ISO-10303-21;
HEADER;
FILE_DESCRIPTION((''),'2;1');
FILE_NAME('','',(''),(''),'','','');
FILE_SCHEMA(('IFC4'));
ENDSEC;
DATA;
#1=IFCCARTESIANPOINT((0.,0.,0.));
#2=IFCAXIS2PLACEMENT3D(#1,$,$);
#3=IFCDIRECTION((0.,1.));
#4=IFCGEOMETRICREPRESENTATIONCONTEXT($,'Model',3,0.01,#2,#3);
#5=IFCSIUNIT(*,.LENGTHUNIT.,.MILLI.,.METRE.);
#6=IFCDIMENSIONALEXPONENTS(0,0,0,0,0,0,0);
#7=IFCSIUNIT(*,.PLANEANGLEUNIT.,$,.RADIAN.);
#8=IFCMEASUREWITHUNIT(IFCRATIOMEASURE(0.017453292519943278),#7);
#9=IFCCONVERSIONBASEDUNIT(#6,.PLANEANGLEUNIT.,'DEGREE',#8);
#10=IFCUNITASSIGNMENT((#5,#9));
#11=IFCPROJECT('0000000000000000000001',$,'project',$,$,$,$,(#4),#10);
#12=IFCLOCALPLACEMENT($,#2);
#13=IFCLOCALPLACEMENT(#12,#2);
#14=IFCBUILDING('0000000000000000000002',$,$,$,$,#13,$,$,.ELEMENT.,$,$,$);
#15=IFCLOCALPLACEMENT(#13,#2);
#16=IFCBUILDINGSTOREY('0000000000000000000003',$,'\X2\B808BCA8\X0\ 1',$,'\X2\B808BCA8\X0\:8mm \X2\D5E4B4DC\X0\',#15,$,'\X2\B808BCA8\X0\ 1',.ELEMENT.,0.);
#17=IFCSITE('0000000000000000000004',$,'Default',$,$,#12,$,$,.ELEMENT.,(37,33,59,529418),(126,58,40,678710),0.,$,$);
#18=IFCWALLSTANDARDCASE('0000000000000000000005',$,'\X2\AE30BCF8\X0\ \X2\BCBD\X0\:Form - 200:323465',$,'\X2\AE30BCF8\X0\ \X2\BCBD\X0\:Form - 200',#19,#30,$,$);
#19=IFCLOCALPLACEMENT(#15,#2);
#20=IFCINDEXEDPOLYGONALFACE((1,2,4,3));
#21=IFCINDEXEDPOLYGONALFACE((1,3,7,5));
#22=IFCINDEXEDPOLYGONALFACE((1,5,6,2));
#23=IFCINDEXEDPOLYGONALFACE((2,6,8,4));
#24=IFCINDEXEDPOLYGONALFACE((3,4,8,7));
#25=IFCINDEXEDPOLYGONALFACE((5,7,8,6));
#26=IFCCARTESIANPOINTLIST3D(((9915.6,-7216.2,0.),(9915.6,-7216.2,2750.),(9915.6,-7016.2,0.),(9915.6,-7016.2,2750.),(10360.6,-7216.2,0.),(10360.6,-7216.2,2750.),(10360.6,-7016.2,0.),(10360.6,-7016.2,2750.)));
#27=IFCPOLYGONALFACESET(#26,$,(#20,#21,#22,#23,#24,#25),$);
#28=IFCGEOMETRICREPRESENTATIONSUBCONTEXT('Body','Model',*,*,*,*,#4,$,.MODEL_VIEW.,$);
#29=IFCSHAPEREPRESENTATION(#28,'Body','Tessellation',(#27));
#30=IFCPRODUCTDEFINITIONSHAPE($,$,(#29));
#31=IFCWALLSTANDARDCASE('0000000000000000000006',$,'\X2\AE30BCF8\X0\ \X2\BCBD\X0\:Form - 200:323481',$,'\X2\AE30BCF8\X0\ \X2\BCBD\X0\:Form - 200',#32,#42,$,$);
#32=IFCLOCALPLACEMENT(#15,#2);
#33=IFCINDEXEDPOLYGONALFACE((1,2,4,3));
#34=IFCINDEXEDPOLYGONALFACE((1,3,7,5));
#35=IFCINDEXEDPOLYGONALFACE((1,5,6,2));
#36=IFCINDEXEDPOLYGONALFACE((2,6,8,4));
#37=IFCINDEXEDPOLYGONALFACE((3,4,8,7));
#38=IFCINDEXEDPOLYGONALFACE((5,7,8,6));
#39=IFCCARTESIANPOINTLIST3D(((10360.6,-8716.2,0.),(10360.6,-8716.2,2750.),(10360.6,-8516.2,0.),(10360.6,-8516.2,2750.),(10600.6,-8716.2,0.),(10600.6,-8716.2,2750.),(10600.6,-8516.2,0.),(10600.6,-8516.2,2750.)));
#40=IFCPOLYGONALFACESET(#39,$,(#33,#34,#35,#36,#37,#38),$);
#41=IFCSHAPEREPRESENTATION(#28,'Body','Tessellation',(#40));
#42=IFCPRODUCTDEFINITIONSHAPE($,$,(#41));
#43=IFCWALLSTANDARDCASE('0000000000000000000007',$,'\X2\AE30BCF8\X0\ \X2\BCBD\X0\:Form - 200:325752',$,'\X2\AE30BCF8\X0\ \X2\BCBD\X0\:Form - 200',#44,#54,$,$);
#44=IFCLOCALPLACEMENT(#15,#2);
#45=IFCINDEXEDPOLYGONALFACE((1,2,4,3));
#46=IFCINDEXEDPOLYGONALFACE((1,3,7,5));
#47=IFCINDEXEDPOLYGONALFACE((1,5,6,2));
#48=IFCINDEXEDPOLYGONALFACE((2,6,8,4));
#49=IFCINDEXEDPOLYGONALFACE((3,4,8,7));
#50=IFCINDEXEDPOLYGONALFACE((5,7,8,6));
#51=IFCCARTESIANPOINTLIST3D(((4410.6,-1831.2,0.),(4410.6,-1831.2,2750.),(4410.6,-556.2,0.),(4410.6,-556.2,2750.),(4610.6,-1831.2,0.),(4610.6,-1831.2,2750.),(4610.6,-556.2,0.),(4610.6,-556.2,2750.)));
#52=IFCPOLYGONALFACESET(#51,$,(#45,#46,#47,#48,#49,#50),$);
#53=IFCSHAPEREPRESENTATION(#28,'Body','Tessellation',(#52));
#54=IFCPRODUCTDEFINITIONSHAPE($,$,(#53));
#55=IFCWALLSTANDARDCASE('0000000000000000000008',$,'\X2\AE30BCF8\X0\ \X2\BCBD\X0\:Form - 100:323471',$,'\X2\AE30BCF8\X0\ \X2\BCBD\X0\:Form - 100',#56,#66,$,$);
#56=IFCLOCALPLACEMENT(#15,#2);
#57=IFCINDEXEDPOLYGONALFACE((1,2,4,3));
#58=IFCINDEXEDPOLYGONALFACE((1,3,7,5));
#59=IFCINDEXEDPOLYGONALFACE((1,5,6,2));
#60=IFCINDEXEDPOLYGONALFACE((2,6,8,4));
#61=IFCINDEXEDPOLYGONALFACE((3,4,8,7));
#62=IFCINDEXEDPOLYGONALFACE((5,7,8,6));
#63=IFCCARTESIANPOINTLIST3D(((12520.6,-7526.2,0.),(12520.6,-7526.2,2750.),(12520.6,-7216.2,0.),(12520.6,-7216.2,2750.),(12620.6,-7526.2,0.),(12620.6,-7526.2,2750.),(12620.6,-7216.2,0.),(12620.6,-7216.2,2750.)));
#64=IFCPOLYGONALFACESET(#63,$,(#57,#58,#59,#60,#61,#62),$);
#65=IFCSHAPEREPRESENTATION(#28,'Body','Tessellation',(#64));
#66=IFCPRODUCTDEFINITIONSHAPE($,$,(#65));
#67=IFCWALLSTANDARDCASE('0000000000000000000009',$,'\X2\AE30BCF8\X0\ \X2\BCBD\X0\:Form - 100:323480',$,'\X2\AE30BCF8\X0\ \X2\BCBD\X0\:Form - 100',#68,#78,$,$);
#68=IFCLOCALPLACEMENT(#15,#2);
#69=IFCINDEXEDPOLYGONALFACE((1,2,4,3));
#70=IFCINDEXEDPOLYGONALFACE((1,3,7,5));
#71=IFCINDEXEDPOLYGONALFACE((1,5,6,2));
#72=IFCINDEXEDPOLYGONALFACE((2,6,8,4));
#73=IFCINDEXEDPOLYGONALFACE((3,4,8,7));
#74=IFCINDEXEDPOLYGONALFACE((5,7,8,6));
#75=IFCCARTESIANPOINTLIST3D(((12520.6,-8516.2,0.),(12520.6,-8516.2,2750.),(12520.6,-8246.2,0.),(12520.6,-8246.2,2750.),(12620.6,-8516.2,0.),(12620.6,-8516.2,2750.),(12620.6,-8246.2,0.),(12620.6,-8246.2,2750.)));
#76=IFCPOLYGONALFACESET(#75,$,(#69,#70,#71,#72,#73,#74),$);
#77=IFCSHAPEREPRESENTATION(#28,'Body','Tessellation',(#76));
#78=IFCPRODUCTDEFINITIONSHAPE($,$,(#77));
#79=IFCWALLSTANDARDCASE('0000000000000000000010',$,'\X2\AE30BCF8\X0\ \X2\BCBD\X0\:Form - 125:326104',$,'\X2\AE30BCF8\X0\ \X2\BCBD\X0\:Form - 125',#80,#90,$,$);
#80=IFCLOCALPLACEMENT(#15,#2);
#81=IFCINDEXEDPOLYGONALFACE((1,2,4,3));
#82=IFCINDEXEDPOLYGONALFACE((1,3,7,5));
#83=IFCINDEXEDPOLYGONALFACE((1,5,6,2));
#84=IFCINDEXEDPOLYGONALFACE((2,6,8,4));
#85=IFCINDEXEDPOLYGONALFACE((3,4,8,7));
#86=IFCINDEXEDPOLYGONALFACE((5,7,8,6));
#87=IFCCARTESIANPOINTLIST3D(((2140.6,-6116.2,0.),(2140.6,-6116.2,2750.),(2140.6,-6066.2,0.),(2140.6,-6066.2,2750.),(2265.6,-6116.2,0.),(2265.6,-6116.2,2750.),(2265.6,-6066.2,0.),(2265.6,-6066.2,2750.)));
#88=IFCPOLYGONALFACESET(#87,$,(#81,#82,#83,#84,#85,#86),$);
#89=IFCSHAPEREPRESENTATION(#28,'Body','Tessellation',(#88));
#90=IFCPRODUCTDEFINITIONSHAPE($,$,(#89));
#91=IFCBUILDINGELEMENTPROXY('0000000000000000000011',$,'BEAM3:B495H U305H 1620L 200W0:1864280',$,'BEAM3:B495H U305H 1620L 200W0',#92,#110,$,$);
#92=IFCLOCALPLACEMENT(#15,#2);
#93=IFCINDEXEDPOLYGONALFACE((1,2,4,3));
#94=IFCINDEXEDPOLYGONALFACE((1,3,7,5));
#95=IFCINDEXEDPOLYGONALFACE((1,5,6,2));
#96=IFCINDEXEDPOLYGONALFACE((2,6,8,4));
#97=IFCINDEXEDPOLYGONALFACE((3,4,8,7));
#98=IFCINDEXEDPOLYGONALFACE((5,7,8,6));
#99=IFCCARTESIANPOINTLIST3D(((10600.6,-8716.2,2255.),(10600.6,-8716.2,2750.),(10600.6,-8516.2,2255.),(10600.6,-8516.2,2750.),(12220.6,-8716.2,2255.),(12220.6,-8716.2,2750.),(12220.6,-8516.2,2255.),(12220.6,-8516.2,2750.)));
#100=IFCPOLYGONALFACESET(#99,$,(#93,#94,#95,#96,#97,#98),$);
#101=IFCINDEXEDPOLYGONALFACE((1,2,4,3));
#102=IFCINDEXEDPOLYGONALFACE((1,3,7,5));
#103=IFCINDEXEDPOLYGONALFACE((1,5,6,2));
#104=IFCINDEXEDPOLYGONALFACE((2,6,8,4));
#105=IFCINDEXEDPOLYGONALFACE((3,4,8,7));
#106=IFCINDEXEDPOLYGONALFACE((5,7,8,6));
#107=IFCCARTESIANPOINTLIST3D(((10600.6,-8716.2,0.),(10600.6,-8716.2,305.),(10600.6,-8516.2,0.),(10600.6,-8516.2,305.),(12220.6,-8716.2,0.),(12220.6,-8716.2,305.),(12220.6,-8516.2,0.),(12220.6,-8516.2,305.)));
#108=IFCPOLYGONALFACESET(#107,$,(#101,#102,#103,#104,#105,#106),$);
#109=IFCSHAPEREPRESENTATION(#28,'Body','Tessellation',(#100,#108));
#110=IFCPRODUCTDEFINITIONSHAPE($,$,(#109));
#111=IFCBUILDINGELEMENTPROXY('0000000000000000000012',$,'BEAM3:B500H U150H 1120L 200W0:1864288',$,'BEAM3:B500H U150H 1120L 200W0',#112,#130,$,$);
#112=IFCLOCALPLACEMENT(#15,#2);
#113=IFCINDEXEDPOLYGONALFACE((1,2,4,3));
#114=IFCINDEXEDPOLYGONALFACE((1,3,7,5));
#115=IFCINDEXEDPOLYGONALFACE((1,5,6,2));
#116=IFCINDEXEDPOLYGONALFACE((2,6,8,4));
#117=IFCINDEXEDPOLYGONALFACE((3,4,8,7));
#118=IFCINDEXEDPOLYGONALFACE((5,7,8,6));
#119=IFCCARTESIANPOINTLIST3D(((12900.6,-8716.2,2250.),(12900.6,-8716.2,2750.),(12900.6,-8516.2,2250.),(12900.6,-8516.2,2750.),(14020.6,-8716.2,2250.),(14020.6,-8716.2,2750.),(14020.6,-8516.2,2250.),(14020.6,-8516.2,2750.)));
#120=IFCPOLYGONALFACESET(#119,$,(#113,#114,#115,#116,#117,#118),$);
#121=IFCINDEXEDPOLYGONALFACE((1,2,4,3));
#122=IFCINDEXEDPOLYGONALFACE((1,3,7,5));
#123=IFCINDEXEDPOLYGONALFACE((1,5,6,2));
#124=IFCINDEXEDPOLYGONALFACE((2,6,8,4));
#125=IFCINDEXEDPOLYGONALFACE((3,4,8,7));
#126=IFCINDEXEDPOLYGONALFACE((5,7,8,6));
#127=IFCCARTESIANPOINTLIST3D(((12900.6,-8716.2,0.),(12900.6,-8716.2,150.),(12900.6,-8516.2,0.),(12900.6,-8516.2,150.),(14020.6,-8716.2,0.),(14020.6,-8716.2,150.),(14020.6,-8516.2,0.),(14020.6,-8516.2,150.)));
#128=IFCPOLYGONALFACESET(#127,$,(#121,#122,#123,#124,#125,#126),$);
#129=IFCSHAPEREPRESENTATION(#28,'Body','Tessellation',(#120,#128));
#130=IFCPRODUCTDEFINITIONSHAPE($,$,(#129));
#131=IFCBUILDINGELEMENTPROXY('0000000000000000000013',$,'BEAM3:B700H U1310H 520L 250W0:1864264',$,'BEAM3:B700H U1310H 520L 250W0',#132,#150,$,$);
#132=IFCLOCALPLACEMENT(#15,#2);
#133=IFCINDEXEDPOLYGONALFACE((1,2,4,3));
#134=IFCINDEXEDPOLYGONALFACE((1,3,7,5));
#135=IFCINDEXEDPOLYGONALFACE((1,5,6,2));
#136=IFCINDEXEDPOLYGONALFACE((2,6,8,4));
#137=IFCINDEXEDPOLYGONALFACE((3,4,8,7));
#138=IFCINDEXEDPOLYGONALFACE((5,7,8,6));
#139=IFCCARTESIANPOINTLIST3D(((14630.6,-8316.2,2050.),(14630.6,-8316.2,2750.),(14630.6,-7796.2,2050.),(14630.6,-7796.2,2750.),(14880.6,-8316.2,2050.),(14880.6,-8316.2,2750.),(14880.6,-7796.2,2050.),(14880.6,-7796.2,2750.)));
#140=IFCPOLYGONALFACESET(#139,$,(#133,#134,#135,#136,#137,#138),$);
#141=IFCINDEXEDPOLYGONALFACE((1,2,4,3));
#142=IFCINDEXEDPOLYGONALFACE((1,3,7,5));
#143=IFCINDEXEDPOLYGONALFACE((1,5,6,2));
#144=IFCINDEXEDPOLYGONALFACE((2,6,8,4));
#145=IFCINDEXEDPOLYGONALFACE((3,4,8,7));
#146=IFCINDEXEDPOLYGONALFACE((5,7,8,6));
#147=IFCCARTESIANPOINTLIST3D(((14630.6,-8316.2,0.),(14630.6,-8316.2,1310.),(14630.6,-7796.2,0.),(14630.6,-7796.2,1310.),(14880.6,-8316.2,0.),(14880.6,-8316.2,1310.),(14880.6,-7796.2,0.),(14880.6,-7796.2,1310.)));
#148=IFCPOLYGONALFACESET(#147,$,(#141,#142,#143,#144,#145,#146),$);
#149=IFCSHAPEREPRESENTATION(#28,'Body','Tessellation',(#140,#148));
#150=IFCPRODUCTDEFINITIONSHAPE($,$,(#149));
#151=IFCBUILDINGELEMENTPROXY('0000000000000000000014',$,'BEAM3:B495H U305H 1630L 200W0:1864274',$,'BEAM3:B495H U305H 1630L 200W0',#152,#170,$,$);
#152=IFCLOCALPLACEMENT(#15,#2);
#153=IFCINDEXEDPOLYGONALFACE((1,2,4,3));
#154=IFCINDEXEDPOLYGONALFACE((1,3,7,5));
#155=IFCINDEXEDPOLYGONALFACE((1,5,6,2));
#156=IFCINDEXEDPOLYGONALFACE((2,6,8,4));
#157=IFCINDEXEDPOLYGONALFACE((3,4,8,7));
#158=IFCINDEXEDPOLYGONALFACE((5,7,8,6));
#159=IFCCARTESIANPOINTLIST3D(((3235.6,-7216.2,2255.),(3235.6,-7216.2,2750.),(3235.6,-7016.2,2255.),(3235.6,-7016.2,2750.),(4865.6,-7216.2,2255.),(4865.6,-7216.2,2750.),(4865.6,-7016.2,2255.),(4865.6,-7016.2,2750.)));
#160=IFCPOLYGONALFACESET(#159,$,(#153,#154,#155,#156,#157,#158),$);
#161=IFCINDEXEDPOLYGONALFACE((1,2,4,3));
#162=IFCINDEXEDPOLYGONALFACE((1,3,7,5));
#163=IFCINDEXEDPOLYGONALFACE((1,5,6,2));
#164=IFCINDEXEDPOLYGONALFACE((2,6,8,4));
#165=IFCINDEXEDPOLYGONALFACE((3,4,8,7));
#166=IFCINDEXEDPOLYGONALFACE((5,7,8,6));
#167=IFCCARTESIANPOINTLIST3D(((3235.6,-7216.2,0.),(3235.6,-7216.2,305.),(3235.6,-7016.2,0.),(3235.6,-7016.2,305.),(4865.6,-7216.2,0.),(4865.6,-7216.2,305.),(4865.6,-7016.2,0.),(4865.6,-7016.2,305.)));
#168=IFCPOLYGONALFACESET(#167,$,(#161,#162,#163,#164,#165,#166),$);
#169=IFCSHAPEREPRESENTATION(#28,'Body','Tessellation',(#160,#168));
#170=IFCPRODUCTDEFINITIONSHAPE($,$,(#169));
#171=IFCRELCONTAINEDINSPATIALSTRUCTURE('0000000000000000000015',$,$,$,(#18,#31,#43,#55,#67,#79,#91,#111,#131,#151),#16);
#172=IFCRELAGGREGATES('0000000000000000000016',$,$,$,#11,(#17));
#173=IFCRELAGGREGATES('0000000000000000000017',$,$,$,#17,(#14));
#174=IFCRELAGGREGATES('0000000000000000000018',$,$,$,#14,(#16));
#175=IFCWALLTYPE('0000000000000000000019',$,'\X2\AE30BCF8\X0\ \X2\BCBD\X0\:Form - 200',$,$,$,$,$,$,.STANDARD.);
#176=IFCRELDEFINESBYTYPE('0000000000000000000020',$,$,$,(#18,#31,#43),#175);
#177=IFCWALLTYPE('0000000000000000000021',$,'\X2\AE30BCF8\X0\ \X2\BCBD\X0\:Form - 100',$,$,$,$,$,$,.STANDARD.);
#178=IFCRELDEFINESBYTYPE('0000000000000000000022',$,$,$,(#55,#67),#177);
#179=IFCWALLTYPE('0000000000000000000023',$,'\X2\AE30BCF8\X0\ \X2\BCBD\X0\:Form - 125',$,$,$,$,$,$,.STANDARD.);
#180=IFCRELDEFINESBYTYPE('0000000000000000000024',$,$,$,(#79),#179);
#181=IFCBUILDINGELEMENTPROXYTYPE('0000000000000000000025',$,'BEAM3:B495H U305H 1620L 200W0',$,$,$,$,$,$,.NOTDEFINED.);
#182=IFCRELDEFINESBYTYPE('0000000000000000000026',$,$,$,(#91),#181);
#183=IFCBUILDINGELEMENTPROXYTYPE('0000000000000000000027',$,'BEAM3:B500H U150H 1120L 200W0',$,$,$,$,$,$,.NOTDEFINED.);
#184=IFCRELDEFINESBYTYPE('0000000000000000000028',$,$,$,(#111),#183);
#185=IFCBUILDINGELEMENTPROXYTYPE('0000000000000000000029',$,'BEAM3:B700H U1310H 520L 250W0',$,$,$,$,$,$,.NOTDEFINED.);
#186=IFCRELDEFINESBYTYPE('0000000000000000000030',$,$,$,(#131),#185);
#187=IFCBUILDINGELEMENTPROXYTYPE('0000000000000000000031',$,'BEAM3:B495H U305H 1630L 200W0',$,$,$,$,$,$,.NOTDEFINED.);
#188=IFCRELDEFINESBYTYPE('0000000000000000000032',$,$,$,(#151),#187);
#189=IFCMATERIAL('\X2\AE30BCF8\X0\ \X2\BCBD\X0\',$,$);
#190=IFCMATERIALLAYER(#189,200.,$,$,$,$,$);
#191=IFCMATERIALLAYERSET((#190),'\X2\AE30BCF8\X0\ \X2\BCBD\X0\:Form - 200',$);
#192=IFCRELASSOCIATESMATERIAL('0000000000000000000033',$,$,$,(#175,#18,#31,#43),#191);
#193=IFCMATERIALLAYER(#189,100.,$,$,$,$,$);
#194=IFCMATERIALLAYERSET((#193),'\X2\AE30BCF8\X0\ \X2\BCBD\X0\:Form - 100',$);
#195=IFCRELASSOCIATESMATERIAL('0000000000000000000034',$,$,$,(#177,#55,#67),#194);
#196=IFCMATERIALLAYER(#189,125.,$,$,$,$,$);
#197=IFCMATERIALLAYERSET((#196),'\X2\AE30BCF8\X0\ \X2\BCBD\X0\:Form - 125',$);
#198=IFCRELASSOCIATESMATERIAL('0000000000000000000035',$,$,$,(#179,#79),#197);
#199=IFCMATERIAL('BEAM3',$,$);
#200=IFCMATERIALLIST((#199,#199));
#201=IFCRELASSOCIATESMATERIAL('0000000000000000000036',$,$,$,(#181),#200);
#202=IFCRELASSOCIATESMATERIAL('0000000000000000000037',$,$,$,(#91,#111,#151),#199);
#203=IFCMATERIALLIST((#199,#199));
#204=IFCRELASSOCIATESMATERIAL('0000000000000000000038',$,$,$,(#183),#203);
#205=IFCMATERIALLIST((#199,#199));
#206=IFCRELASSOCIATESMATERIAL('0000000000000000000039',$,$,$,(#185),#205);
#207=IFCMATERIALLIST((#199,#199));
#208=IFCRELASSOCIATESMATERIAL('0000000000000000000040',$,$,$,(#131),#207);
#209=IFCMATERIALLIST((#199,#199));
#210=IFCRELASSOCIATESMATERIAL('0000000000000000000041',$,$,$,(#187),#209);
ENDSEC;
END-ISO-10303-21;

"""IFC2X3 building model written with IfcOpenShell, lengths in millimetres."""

from ifc_helpers import new_model, entity, si_unit, converted_unit, direction, frame, frame_2d, origin, origin_2d_with_axis, place, context, subcontext, project, spatial, rectangle, extrude, source, transform, mapped, material, material_list, layer, layer_set, layer_usage, type_object, type_shapes, element, save


model = new_model("IFC2X3")

# Units and contexts
model_context = context("Model", 3, precision=0.01, world=origin(), true_north=direction((0.0, 1.0)))
body_context = subcontext(model_context, "Body", "Model", "MODEL_VIEW")
ifc_project = project(units=[si_unit("LENGTHUNIT", "METRE", prefix="MILLI"), converted_unit("PLANEANGLEUNIT", "DEGREE", entity("IfcRatioMeasure", 0.017453292519943278), si_unit("PLANEANGLEUNIT", "RADIAN"), dimensions=[0, 0, 0, 0, 0, 0, 0])], contexts=[model_context])

# Site, building, storey
site_placement = place(None, origin())
site = spatial("IfcSite", under=ifc_project, at=site_placement, Name="Default", CompositionType="ELEMENT", RefLatitude=(37, 33, 59, 529418), RefLongitude=(126, 58, 40, 678710), RefElevation=0.0)
building_placement = place(site_placement, origin())
building = spatial("IfcBuilding", under=site, at=building_placement, CompositionType="ELEMENT")
storey_placement = place(building_placement, origin())
storey = spatial("IfcBuildingStorey", under=building, at=storey_placement, Name="레벨 1", ObjectType="레벨:8mm 헤드", LongName="레벨 1", CompositionType="ELEMENT", Elevation=0.0)

# Walls
ifc_material_1 = material(Name="기본 벽")
ifc_layer_1 = layer(ifc_material_1, 200.0)
ifc_layer_set_1 = layer_set([ifc_layer_1], Name="기본 벽:Form - 200")
wall_type_1 = type_object("IfcWallType", Name="기본 벽:Form - 200", PredefinedType="STANDARD", material=ifc_layer_set_1)
ifc_layer_usage_1 = layer_usage(ifc_layer_set_1, "AXIS2", "POSITIVE", -100.0)
wall_1_placement = place(storey_placement, frame((10360.6, -7116.2, 0.0), z_axis=(0.0, 0.0, 1.0), x_axis=(-1.0, 0.0, 0.0)))
element("IfcWallStandardCase", 1, at=wall_1_placement, inside=storey, type_object=wall_type_1, material=ifc_layer_usage_1, Name="기본 벽:Form - 200:323465", ObjectType="기본 벽:Form - 200", context=body_context, shape_type="SweptSolid", body=[
    extrude(rectangle(XDim=445.0, YDim=200.0, at=frame_2d((222.5, 0.0), x_axis=(-1.0, 0.0))), origin(), (0.0, 0.0, 1.0), 2750.0),
])
ifc_layer_usage_2 = layer_usage(ifc_layer_set_1, "AXIS2", "POSITIVE", -100.0)
wall_2_placement = place(storey_placement, frame((10360.6, -8616.2, 0.0)))
element("IfcWallStandardCase", 2, at=wall_2_placement, inside=storey, type_object=wall_type_1, material=ifc_layer_usage_2, Name="기본 벽:Form - 200:323481", ObjectType="기본 벽:Form - 200", context=body_context, shape_type="SweptSolid", body=[
    extrude(rectangle(XDim=240.0, YDim=200.0, at=frame_2d((120.0, 0.0), x_axis=(-1.0, 0.0))), origin(), (0.0, 0.0, 1.0), 2750.0),
])
ifc_layer_usage_3 = layer_usage(ifc_layer_set_1, "AXIS2", "POSITIVE", -100.0)
wall_3_placement = place(storey_placement, frame((4510.6, -556.2, 0.0), z_axis=(0.0, 0.0, 1.0), x_axis=(0.0, -1.0, 0.0)))
element("IfcWallStandardCase", 3, at=wall_3_placement, inside=storey, type_object=wall_type_1, material=ifc_layer_usage_3, Name="기본 벽:Form - 200:325752", ObjectType="기본 벽:Form - 200", context=body_context, shape_type="SweptSolid", body=[
    extrude(rectangle(XDim=1275.0, YDim=200.0, at=frame_2d((637.5, 0.0), x_axis=(-1.0, 0.0))), origin(), (0.0, 0.0, 1.0), 2750.0),
])
ifc_layer_2 = layer(ifc_material_1, 100.0)
ifc_layer_set_2 = layer_set([ifc_layer_2], Name="기본 벽:Form - 100")
ifc_layer_usage_4 = layer_usage(ifc_layer_set_2, "AXIS2", "POSITIVE", -50.0)
wall_type_2 = type_object("IfcWallType", Name="기본 벽:Form - 100", PredefinedType="STANDARD", material=ifc_layer_set_2)
wall_4_placement = place(storey_placement, frame((12570.6, -7526.2, 0.0), z_axis=(0.0, 0.0, 1.0), x_axis=(0.0, 1.0, 0.0)))
element("IfcWallStandardCase", 4, at=wall_4_placement, inside=storey, type_object=wall_type_2, material=ifc_layer_usage_4, Name="기본 벽:Form - 100:323471", ObjectType="기본 벽:Form - 100", context=body_context, shape_type="SweptSolid", body=[
    extrude(rectangle(XDim=310.0, YDim=100.0, at=frame_2d((155.0, 0.0), x_axis=(-1.0, 0.0))), origin(), (0.0, 0.0, 1.0), 2750.0),
])
ifc_layer_usage_5 = layer_usage(ifc_layer_set_2, "AXIS2", "POSITIVE", -50.0)
wall_5_placement = place(storey_placement, frame((12570.6, -8516.2, 0.0), z_axis=(0.0, 0.0, 1.0), x_axis=(0.0, 1.0, 0.0)))
element("IfcWallStandardCase", 5, at=wall_5_placement, inside=storey, type_object=wall_type_2, material=ifc_layer_usage_5, Name="기본 벽:Form - 100:323480", ObjectType="기본 벽:Form - 100", context=body_context, shape_type="SweptSolid", body=[
    extrude(rectangle(XDim=270.0, YDim=100.0, at=frame_2d((135.0, 0.0), x_axis=(-1.0, 0.0))), origin(), (0.0, 0.0, 1.0), 2750.0),
])
ifc_layer_3 = layer(ifc_material_1, 125.0)
ifc_layer_set_3 = layer_set([ifc_layer_3], Name="기본 벽:Form - 125")
ifc_layer_usage_6 = layer_usage(ifc_layer_set_3, "AXIS2", "POSITIVE", -62.5)
wall_type_3 = type_object("IfcWallType", Name="기본 벽:Form - 125", PredefinedType="STANDARD", material=ifc_layer_set_3)
wall_6_placement = place(storey_placement, frame((2203.1, -6116.2, 0.0), z_axis=(0.0, 0.0, 1.0), x_axis=(0.0, 1.0, 0.0)))
element("IfcWallStandardCase", 6, at=wall_6_placement, inside=storey, type_object=wall_type_3, material=ifc_layer_usage_6, Name="기본 벽:Form - 125:326104", ObjectType="기본 벽:Form - 125", context=body_context, shape_type="SweptSolid", body=[
    extrude(rectangle(XDim=50.0, YDim=125.0, at=frame_2d((25.0, 0.0), x_axis=(-1.0, 0.0))), origin(), (0.0, 0.0, 1.0), 2750.0),
])

# Building element proxies
ifc_material_2 = material(Name="BEAM3")
ifc_material_list_1 = material_list([ifc_material_2, ifc_material_2])
building_element_proxy_type_1 = type_object("IfcBuildingElementProxyType", Name="BEAM3:B495H U305H 1620L 200W0", PredefinedType="NOTDEFINED", material=ifc_material_list_1)
shared_shape_1 = source(origin(), body_context, "Body", "SweptSolid", [
    extrude(rectangle(XDim=1620.0, YDim=200.0, at=origin_2d_with_axis()), frame((810.0, -100.0, 2255.0)), (0.0, 0.0, 1.0), 495.0),
    extrude(rectangle(XDim=1620.0, YDim=200.0, at=origin_2d_with_axis()), frame((810.0, -100.0, 0.0)), (0.0, 0.0, 1.0), 305.0),
])
type_shapes(building_element_proxy_type_1, [shared_shape_1])
proxy_1_placement = place(storey_placement, frame((10600.6, -8516.2, 0.0)))
element("IfcBuildingElementProxy", 7, at=proxy_1_placement, inside=storey, type_object=building_element_proxy_type_1, material=ifc_material_2, Name="BEAM3:B495H U305H 1620L 200W0:1864280", ObjectType="BEAM3:B495H U305H 1620L 200W0", context=body_context, shape_type="MappedRepresentation", body=[
    mapped(shared_shape_1, transform((0.0, 0.0, 0.0), scale=1.0)),
])
ifc_material_list_2 = material_list([ifc_material_2, ifc_material_2])
building_element_proxy_type_2 = type_object("IfcBuildingElementProxyType", Name="BEAM3:B500H U150H 1120L 200W0", PredefinedType="NOTDEFINED", material=ifc_material_list_2)
shared_shape_2 = source(origin(), body_context, "Body", "SweptSolid", [
    extrude(rectangle(XDim=1120.0, YDim=200.0, at=origin_2d_with_axis()), frame((560.0, -100.0, 2250.0)), (0.0, 0.0, 1.0), 500.0),
    extrude(rectangle(XDim=1120.0, YDim=200.0, at=origin_2d_with_axis()), frame((560.0, -100.0, 0.0)), (0.0, 0.0, 1.0), 150.0),
])
type_shapes(building_element_proxy_type_2, [shared_shape_2])
proxy_2_placement = place(storey_placement, frame((12900.6, -8516.2, 0.0)))
element("IfcBuildingElementProxy", 8, at=proxy_2_placement, inside=storey, type_object=building_element_proxy_type_2, material=ifc_material_2, Name="BEAM3:B500H U150H 1120L 200W0:1864288", ObjectType="BEAM3:B500H U150H 1120L 200W0", context=body_context, shape_type="MappedRepresentation", body=[
    mapped(shared_shape_2, transform((0.0, 0.0, 0.0), scale=1.0)),
])
ifc_material_list_3 = material_list([ifc_material_2, ifc_material_2])
ifc_material_list_4 = material_list([ifc_material_2, ifc_material_2])
building_element_proxy_type_3 = type_object("IfcBuildingElementProxyType", Name="BEAM3:B700H U1310H 520L 250W0", PredefinedType="NOTDEFINED", material=ifc_material_list_4)
shared_shape_3 = source(origin(), body_context, "Body", "SweptSolid", [
    extrude(rectangle(XDim=520.0, YDim=250.0, at=origin_2d_with_axis()), frame((260.0, -125.0, 2050.0)), (0.0, 0.0, 1.0), 700.0),
    extrude(rectangle(XDim=520.0, YDim=250.0, at=origin_2d_with_axis()), frame((260.0, -125.0, 0.0)), (0.0, 0.0, 1.0), 1310.0),
])
type_shapes(building_element_proxy_type_3, [shared_shape_3])
proxy_3_placement = place(storey_placement, frame((14630.6, -8316.2, 0.0), z_axis=(0.0, 0.0, 1.0), x_axis=(0.0, 1.0, 0.0)))
element("IfcBuildingElementProxy", 9, at=proxy_3_placement, inside=storey, type_object=building_element_proxy_type_3, material=ifc_material_list_3, Name="BEAM3:B700H U1310H 520L 250W0:1864264", ObjectType="BEAM3:B700H U1310H 520L 250W0", context=body_context, shape_type="MappedRepresentation", body=[
    mapped(shared_shape_3, transform((0.0, 0.0, 0.0), scale=1.0)),
])
ifc_material_list_5 = material_list([ifc_material_2, ifc_material_2])
building_element_proxy_type_4 = type_object("IfcBuildingElementProxyType", Name="BEAM3:B495H U305H 1630L 200W0", PredefinedType="NOTDEFINED", material=ifc_material_list_5)
shared_shape_4 = source(origin(), body_context, "Body", "SweptSolid", [
    extrude(rectangle(XDim=1630.0, YDim=200.0, at=origin_2d_with_axis()), frame((815.0, -100.0, 2255.0)), (0.0, 0.0, 1.0), 495.0),
    extrude(rectangle(XDim=1630.0, YDim=200.0, at=origin_2d_with_axis()), frame((815.0, -100.0, 0.0)), (0.0, 0.0, 1.0), 305.0),
])
type_shapes(building_element_proxy_type_4, [shared_shape_4])
proxy_4_placement = place(storey_placement, frame((3235.6, -7016.2, 0.0)))
element("IfcBuildingElementProxy", 10, at=proxy_4_placement, inside=storey, type_object=building_element_proxy_type_4, material=ifc_material_2, Name="BEAM3:B495H U305H 1630L 200W0:1864274", ObjectType="BEAM3:B495H U305H 1630L 200W0", context=body_context, shape_type="MappedRepresentation", body=[
    mapped(shared_shape_4, transform((0.0, 0.0, 0.0), scale=1.0)),
])

save(model, "model.ifc")
